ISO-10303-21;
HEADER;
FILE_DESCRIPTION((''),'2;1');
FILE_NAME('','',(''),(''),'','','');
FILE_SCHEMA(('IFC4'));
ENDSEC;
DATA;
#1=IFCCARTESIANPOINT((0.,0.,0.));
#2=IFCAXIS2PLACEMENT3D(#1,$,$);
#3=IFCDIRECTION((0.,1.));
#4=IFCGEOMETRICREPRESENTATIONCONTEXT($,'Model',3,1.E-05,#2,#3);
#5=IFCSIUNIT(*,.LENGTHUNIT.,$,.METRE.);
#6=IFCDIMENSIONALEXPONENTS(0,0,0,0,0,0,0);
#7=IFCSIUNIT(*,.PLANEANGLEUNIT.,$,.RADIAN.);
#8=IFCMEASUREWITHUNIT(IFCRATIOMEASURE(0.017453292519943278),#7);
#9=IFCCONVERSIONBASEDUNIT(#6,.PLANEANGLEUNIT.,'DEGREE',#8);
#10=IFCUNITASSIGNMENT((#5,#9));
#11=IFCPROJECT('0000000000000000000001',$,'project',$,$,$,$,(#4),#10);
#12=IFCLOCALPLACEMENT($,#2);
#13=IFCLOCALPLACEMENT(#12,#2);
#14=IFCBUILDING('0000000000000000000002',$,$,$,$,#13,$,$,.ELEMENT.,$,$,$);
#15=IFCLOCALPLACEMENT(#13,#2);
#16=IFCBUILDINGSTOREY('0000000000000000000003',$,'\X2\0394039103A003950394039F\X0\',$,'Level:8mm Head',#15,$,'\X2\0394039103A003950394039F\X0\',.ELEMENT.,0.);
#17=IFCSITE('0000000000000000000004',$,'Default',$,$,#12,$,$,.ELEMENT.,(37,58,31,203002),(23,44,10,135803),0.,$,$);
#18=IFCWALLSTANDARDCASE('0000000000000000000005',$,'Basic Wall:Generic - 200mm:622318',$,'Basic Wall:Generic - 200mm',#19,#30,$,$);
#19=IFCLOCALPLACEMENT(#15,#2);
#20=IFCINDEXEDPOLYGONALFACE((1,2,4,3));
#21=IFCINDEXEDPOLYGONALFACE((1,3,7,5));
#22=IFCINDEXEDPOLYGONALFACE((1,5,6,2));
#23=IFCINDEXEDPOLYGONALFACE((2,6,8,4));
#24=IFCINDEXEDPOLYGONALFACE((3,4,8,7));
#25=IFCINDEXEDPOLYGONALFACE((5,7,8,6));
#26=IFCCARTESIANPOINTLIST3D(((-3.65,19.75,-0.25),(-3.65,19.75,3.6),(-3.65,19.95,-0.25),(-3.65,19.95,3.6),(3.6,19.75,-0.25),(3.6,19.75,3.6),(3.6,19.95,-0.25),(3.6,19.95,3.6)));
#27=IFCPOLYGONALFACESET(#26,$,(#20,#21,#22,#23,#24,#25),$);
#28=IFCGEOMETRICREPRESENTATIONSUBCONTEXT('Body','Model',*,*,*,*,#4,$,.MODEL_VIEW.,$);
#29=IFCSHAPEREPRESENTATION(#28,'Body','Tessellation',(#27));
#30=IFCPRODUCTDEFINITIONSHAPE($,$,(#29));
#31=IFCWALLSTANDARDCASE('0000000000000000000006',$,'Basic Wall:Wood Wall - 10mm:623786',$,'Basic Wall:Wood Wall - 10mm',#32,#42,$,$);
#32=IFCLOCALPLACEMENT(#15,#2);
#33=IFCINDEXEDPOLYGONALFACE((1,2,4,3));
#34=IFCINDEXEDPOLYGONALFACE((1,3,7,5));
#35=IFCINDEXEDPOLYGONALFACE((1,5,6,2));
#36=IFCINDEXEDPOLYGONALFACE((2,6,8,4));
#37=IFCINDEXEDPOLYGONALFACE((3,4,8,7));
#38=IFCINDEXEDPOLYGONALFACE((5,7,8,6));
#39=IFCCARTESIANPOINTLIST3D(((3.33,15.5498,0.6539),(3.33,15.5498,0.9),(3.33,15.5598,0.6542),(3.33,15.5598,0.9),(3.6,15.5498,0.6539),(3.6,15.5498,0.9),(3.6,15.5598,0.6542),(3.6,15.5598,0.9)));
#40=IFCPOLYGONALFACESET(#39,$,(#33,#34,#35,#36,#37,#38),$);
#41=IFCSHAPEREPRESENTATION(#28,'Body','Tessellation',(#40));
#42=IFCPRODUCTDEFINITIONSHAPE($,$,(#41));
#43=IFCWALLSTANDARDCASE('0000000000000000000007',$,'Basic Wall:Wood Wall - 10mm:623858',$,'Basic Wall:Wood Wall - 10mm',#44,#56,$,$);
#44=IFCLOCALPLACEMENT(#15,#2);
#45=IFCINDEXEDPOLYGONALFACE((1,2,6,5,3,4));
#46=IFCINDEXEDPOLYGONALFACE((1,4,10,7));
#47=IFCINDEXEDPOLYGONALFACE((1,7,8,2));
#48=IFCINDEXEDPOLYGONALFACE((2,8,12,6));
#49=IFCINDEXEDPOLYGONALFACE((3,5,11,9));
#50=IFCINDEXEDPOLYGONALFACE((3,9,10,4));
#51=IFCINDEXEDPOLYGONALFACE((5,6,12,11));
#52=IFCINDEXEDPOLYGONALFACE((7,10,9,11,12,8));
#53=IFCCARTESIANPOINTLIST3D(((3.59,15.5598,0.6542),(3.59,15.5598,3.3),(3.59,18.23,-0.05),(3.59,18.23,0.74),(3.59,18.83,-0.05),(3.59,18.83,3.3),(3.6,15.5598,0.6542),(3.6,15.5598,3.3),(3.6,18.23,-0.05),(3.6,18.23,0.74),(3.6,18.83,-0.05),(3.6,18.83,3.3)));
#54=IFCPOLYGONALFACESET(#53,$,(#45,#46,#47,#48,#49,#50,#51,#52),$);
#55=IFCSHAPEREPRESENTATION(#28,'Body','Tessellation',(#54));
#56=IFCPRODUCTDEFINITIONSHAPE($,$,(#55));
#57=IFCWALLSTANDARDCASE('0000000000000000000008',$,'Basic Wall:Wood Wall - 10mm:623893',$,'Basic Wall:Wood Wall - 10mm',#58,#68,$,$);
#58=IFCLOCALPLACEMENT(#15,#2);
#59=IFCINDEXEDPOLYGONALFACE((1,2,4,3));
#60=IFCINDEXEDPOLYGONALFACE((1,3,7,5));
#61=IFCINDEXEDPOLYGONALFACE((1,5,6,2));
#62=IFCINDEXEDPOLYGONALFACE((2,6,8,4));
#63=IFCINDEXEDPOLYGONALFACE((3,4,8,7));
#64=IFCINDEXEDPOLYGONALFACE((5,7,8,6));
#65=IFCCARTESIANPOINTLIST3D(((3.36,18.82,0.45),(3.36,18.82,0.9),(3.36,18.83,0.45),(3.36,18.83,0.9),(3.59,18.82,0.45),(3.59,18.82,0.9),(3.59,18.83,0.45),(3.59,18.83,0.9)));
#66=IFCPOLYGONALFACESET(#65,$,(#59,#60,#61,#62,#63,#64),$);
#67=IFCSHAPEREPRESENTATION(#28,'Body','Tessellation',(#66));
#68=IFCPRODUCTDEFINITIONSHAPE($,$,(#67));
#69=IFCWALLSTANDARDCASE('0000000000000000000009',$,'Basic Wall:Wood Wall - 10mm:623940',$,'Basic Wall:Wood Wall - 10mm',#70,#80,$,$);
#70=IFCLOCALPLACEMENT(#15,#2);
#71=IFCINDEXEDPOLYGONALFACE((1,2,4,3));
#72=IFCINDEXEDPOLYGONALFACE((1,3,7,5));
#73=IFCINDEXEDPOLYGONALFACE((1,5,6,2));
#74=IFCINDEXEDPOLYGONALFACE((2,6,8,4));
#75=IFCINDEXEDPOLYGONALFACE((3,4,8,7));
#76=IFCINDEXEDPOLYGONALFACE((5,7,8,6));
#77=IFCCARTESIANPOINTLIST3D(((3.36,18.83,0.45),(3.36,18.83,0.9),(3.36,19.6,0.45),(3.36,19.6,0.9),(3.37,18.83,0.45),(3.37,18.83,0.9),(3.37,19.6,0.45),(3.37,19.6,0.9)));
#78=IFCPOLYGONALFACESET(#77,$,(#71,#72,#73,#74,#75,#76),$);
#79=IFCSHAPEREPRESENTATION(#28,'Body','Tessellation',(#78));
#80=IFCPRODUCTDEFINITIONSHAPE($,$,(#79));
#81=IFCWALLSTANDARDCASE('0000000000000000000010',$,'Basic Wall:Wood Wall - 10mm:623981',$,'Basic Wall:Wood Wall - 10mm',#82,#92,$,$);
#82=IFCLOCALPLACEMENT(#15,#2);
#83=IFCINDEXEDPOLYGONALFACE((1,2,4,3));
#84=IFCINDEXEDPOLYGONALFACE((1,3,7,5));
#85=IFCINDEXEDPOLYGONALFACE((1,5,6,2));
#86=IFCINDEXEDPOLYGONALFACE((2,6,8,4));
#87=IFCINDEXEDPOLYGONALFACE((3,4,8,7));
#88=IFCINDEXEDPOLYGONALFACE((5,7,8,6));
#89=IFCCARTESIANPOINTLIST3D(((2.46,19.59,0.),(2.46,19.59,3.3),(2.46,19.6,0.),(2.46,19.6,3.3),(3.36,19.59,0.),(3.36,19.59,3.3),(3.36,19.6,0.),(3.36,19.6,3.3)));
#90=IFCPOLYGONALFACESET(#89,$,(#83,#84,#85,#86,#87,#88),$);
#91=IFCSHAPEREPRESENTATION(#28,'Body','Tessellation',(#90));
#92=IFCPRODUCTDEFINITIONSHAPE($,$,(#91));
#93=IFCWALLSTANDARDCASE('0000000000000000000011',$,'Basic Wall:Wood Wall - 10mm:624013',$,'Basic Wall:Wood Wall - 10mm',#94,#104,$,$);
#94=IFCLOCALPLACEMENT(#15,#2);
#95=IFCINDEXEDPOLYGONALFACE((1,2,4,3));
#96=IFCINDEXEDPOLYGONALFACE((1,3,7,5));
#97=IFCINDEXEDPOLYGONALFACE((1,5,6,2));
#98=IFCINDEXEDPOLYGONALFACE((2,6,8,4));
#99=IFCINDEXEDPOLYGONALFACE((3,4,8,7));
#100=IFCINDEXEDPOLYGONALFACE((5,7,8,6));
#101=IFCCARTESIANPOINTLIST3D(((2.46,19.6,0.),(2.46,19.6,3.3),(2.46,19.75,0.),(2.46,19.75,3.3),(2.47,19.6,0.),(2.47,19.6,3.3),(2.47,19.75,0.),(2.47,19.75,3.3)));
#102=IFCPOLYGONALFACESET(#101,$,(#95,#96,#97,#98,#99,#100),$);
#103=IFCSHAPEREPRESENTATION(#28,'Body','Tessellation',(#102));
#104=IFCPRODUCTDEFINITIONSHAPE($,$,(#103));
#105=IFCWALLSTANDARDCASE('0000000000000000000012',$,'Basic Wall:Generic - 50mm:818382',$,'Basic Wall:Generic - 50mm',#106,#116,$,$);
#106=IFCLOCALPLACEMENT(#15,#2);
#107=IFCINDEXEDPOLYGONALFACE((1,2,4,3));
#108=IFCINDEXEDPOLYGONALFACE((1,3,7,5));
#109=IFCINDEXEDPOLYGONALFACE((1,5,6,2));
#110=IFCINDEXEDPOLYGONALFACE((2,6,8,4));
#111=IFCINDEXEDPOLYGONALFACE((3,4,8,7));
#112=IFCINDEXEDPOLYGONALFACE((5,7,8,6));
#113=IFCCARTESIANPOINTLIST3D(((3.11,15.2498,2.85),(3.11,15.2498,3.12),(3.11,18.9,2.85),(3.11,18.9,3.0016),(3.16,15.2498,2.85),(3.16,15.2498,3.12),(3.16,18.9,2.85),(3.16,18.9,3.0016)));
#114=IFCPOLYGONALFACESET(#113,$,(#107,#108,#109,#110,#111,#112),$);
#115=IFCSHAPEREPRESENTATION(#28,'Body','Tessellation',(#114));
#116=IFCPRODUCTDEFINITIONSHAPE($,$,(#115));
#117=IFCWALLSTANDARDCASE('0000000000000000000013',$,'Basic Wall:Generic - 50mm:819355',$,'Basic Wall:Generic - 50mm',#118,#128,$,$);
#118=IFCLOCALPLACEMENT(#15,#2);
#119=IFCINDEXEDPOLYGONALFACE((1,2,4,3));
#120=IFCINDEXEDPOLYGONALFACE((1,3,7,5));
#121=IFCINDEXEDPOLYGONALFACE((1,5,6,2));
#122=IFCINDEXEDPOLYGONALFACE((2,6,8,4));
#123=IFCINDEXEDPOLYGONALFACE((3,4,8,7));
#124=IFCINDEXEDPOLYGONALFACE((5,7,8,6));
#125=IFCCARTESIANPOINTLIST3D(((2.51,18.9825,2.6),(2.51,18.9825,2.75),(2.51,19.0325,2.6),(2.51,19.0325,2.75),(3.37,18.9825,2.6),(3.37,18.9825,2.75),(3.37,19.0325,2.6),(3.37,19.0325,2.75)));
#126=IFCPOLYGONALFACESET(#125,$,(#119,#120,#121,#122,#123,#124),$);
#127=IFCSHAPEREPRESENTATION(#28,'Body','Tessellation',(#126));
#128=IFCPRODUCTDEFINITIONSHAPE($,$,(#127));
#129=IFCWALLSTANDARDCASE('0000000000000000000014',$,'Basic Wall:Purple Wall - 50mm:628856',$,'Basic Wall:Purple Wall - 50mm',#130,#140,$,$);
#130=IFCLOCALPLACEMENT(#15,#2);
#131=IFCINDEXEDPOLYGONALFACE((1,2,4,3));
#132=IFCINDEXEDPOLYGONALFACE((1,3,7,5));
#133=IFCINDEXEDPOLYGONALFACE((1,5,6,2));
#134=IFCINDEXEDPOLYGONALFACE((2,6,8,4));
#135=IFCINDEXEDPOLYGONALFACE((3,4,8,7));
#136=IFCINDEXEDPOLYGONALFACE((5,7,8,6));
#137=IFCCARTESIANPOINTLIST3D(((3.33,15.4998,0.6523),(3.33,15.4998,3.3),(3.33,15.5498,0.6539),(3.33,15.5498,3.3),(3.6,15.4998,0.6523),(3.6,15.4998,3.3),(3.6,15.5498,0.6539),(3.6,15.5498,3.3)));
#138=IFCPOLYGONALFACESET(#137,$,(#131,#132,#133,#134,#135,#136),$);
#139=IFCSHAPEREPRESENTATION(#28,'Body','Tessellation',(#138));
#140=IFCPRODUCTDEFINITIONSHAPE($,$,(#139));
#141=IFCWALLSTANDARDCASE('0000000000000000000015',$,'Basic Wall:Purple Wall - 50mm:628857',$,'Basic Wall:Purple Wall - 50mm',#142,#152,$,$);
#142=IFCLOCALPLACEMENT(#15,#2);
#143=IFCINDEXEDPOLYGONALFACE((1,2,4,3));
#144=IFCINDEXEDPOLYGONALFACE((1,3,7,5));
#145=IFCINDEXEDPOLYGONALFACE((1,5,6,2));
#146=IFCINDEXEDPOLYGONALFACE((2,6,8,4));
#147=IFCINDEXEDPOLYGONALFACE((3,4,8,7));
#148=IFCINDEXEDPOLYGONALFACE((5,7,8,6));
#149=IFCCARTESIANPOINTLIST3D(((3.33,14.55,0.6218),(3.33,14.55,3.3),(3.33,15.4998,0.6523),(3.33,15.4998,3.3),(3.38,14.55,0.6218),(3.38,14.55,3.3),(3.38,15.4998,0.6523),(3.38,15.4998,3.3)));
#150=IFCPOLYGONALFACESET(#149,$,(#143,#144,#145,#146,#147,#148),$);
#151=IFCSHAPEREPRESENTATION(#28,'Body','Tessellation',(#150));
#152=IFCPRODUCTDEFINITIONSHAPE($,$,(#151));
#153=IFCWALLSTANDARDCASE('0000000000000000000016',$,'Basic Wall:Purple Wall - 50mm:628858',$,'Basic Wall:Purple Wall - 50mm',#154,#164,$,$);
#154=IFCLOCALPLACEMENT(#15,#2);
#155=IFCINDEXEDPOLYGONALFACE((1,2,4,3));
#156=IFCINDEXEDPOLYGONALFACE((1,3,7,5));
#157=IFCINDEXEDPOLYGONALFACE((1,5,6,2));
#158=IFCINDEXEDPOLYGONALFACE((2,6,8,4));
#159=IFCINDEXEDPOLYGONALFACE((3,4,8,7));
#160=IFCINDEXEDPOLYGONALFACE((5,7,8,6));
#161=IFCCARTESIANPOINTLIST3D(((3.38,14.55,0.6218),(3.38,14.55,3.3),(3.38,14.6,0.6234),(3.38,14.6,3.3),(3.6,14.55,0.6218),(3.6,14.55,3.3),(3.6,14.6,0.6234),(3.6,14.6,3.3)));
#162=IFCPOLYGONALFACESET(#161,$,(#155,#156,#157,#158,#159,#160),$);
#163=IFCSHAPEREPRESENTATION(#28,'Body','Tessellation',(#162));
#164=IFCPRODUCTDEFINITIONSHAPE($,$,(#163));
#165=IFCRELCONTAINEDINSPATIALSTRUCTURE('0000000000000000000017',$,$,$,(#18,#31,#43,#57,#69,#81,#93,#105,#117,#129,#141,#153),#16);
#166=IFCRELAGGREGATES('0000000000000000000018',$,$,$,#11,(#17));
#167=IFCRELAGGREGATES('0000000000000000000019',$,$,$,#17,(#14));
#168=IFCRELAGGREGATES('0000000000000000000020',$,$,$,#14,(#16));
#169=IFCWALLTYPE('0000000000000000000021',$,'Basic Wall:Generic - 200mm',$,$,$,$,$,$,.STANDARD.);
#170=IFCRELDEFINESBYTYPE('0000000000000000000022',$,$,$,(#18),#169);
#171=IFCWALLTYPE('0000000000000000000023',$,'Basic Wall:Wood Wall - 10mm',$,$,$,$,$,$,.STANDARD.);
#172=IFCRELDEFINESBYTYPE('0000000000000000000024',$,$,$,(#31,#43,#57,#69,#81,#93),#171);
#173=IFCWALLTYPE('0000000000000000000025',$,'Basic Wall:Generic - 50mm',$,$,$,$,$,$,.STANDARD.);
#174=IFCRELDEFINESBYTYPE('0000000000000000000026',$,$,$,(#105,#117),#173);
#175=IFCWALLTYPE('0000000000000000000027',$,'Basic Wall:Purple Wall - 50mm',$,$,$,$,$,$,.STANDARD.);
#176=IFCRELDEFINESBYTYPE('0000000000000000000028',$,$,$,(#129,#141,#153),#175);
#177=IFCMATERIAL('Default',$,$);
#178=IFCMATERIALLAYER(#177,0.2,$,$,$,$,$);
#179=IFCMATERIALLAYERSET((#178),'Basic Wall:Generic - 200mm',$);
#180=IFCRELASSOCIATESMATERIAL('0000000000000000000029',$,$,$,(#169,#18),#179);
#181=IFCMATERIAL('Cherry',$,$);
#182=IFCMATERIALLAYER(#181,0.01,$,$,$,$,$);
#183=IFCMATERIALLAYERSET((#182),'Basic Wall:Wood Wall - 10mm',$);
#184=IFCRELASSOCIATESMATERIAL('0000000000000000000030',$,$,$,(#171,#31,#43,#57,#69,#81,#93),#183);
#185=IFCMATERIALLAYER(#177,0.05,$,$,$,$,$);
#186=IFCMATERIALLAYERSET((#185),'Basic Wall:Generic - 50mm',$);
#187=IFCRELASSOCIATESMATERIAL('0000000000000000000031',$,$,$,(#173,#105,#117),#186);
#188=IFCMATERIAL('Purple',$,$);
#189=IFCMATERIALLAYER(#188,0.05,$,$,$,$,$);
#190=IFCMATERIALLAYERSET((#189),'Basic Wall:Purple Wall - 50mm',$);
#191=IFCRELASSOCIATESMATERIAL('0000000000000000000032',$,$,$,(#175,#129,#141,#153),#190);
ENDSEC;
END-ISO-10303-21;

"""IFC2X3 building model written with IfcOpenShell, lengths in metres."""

from ifc_helpers import new_model, entity, si_unit, converted_unit, direction, frame, frame_2d, origin, place, context, subcontext, project, spatial, polyline, rectangle, extrude, clip, bounded_halfspace, material, layer, layer_set, layer_usage, type_object, element, save


model = new_model("IFC2X3")

# Units and contexts
model_context = context("Model", 3, precision=1e-05, world=origin(), true_north=direction((0.0, 1.0)))
body_context = subcontext(model_context, "Body", "Model", "MODEL_VIEW")
ifc_project = project(units=[si_unit("LENGTHUNIT", "METRE"), converted_unit("PLANEANGLEUNIT", "DEGREE", entity("IfcRatioMeasure", 0.017453292519943278), si_unit("PLANEANGLEUNIT", "RADIAN"), dimensions=[0, 0, 0, 0, 0, 0, 0])], contexts=[model_context])

# Site, building, storey
site_placement = place(None, origin())
site = spatial("IfcSite", under=ifc_project, at=site_placement, Name="Default", CompositionType="ELEMENT", RefLatitude=(37, 58, 31, 203002), RefLongitude=(23, 44, 10, 135803), RefElevation=0.0)
building_placement = place(site_placement, origin())
building = spatial("IfcBuilding", under=site, at=building_placement, CompositionType="ELEMENT")
storey_placement = place(building_placement, origin())
storey = spatial("IfcBuildingStorey", under=building, at=storey_placement, Name="ΔΑΠΕΔΟ", ObjectType="Level:8mm Head", LongName="ΔΑΠΕΔΟ", CompositionType="ELEMENT", Elevation=0.0)

# Walls
ifc_material_1 = material(Name="Default")
ifc_layer_1 = layer(ifc_material_1, 0.2)
ifc_layer_set_1 = layer_set([ifc_layer_1], Name="Basic Wall:Generic - 200mm")
ifc_layer_usage_1 = layer_usage(ifc_layer_set_1, "AXIS2", "NEGATIVE", 0.1)
wall_type_1 = type_object("IfcWallType", Name="Basic Wall:Generic - 200mm", PredefinedType="STANDARD", material=ifc_layer_set_1)
wall_1_placement = place(storey_placement, frame((3.6, 19.85, -0.25), z_axis=(0.0, 0.0, 1.0), x_axis=(-1.0, 0.0, 0.0)))
element("IfcWallStandardCase", 1, at=wall_1_placement, inside=storey, type_object=wall_type_1, material=ifc_layer_usage_1, Name="Basic Wall:Generic - 200mm:622318", ObjectType="Basic Wall:Generic - 200mm", context=body_context, shape_type="SweptSolid", body=[
    extrude(rectangle(XDim=7.25, YDim=0.2, at=frame_2d((3.625, 0.0), x_axis=(-1.0, 0.0))), origin(), (0.0, 0.0, 1.0), 3.85),
])
ifc_material_2 = material(Name="Cherry")
ifc_layer_2 = layer(ifc_material_2, 0.01)
ifc_layer_set_2 = layer_set([ifc_layer_2], Name="Basic Wall:Wood Wall - 10mm")
ifc_layer_usage_2 = layer_usage(ifc_layer_set_2, "AXIS2", "NEGATIVE", 0.005)
wall_type_2 = type_object("IfcWallType", Name="Basic Wall:Wood Wall - 10mm", PredefinedType="STANDARD", material=ifc_layer_set_2)
wall_2_placement = place(storey_placement, frame((3.33, 15.5548, 0.6539)))
element("IfcWallStandardCase", 2, at=wall_2_placement, inside=storey, type_object=wall_type_2, material=ifc_layer_usage_2, Name="Basic Wall:Wood Wall - 10mm:623786", ObjectType="Basic Wall:Wood Wall - 10mm", context=body_context, shape_type="Clipping", body=[
    clip(extrude(rectangle(XDim=0.27, YDim=0.01, at=frame_2d((0.135, 0.0), x_axis=(-1.0, 0.0))), origin(), (0.0, 0.0, 1.0), 0.2461), bounded_halfspace(frame((0.27, -0.005, 0.0), z_axis=(0.0, -0.032108, 0.999484), x_axis=(1.0, 0.0, 0.0)), True, frame((0.27, -0.005, 0.0)), polyline([(0.0, 0.0), (0.0, 0.01), (-0.01, 0.01), (-0.27, 0.01), (-0.27, 0.0), (0.0, 0.0)]))),
])
wall_3_placement = place(storey_placement, frame((3.595, 15.5598, -0.05), z_axis=(0.0, 0.0, 1.0), x_axis=(0.0, 1.0, 0.0)))
element("IfcWallStandardCase", 3, at=wall_3_placement, inside=storey, type_object=wall_type_2, material=ifc_layer_usage_2, Name="Basic Wall:Wood Wall - 10mm:623858", ObjectType="Basic Wall:Wood Wall - 10mm", context=body_context, shape_type="Clipping", body=[
    clip(clip(extrude(rectangle(XDim=3.2702, YDim=0.01, at=frame_2d((1.6351, 0.0), x_axis=(-1.0, 0.0))), origin(), (0.0, 0.0, 1.0), 3.35), bounded_halfspace(frame((2.6702, -0.005, 0.79), z_axis=(-0.032108, 0.0, 0.999484), x_axis=(0.0, -1.0, 0.0)), True, frame((2.6702, -0.005, 0.79)), polyline([(0.0, 0.0), (0.0, 0.01), (-2.6702, 0.01), (-2.6702, 0.0), (0.0, 0.0)]))), bounded_halfspace(frame((3.2702, -0.005, 0.0)), True, frame((3.2702, -0.005, 0.0)), polyline([(0.0, 0.0), (0.0, 0.01), (-0.6, 0.01), (-0.6, 0.0), (0.0, 0.0)]))),
])
wall_4_placement = place(storey_placement, frame((3.59, 18.825, 0.45), z_axis=(0.0, 0.0, 1.0), x_axis=(-1.0, 0.0, 0.0)))
element("IfcWallStandardCase", 4, at=wall_4_placement, inside=storey, type_object=wall_type_2, material=ifc_layer_usage_2, Name="Basic Wall:Wood Wall - 10mm:623893", ObjectType="Basic Wall:Wood Wall - 10mm", context=body_context, shape_type="SweptSolid", body=[
    extrude(rectangle(XDim=0.23, YDim=0.01, at=frame_2d((0.115, 0.0), x_axis=(-1.0, 0.0))), origin(), (0.0, 0.0, 1.0), 0.45),
])
wall_5_placement = place(storey_placement, frame((3.365, 18.83, 0.45), z_axis=(0.0, 0.0, 1.0), x_axis=(0.0, 1.0, 0.0)))
element("IfcWallStandardCase", 5, at=wall_5_placement, inside=storey, type_object=wall_type_2, material=ifc_layer_usage_2, Name="Basic Wall:Wood Wall - 10mm:623940", ObjectType="Basic Wall:Wood Wall - 10mm", context=body_context, shape_type="SweptSolid", body=[
    extrude(rectangle(XDim=0.77, YDim=0.01, at=frame_2d((0.385, 0.0), x_axis=(-1.0, 0.0))), origin(), (0.0, 0.0, 1.0), 0.45),
])
wall_6_placement = place(storey_placement, frame((3.36, 19.595, 0.0), z_axis=(0.0, 0.0, 1.0), x_axis=(-1.0, 0.0, 0.0)))
element("IfcWallStandardCase", 6, at=wall_6_placement, inside=storey, type_object=wall_type_2, material=ifc_layer_usage_2, Name="Basic Wall:Wood Wall - 10mm:623981", ObjectType="Basic Wall:Wood Wall - 10mm", context=body_context, shape_type="SweptSolid", body=[
    extrude(rectangle(XDim=0.9, YDim=0.01, at=frame_2d((0.45, 0.0), x_axis=(-1.0, 0.0))), origin(), (0.0, 0.0, 1.0), 3.3),
])
wall_7_placement = place(storey_placement, frame((2.465, 19.6, 0.0), z_axis=(0.0, 0.0, 1.0), x_axis=(0.0, 1.0, 0.0)))
element("IfcWallStandardCase", 7, at=wall_7_placement, inside=storey, type_object=wall_type_2, material=ifc_layer_usage_2, Name="Basic Wall:Wood Wall - 10mm:624013", ObjectType="Basic Wall:Wood Wall - 10mm", context=body_context, shape_type="SweptSolid", body=[
    extrude(rectangle(XDim=0.15, YDim=0.01, at=frame_2d((0.075, 0.0), x_axis=(-1.0, 0.0))), origin(), (0.0, 0.0, 1.0), 3.3),
])
ifc_layer_3 = layer(ifc_material_1, 0.05)
ifc_layer_set_3 = layer_set([ifc_layer_3], Name="Basic Wall:Generic - 50mm")
ifc_layer_usage_3 = layer_usage(ifc_layer_set_3, "AXIS2", "NEGATIVE", 0.025)
wall_type_3 = type_object("IfcWallType", Name="Basic Wall:Generic - 50mm", PredefinedType="STANDARD", material=ifc_layer_set_3)
wall_8_placement = place(storey_placement, frame((3.135, 15.2498, 2.85), z_axis=(0.0, 0.0, 1.0), x_axis=(0.0, 1.0, 0.0)))
element("IfcWallStandardCase", 8, at=wall_8_placement, inside=storey, type_object=wall_type_3, material=ifc_layer_usage_3, Name="Basic Wall:Generic - 50mm:818382", ObjectType="Basic Wall:Generic - 50mm", context=body_context, shape_type="Clipping", body=[
    clip(extrude(rectangle(XDim=3.6502, YDim=0.05, at=frame_2d((1.8251, 0.0), x_axis=(-1.0, 0.0))), origin(), (0.0, 0.0, 1.0), 0.27), bounded_halfspace(frame((0.0, -0.025, 0.27), z_axis=(-0.032414, 0.0, -0.999475), x_axis=(0.999475, 0.0, -0.032414)), True, frame((0.0, -0.025, 0.27)), polyline([(0.0, 0.0), (3.6502, 0.0), (3.6502, 0.05), (0.0, 0.05), (0.0, 0.0)]))),
])
wall_9_placement = place(storey_placement, frame((2.51, 19.0075, 2.6)))
element("IfcWallStandardCase", 9, at=wall_9_placement, inside=storey, type_object=wall_type_3, material=ifc_layer_usage_3, Name="Basic Wall:Generic - 50mm:819355", ObjectType="Basic Wall:Generic - 50mm", context=body_context, shape_type="SweptSolid", body=[
    extrude(rectangle(XDim=0.86, YDim=0.05, at=frame_2d((0.43, 0.0), x_axis=(-1.0, 0.0))), origin(), (0.0, 0.0, 1.0), 0.15),
])

# Walls
ifc_material_3 = material(Name="Purple")
ifc_layer_4 = layer(ifc_material_3, 0.05)
ifc_layer_set_4 = layer_set([ifc_layer_4], Name="Basic Wall:Purple Wall - 50mm")
ifc_layer_usage_4 = layer_usage(ifc_layer_set_4, "AXIS2", "POSITIVE", -0.025)
wall_type_4 = type_object("IfcWallType", Name="Basic Wall:Purple Wall - 50mm", PredefinedType="STANDARD", material=ifc_layer_set_4)
wall_10_placement = place(storey_placement, frame((3.6, 15.5248, 0.6523), z_axis=(0.0, 0.0, 1.0), x_axis=(-1.0, 0.0, 0.0)))
element("IfcWallStandardCase", 10, at=wall_10_placement, inside=storey, type_object=wall_type_4, material=ifc_layer_usage_4, Name="Basic Wall:Purple Wall - 50mm:628856", ObjectType="Basic Wall:Purple Wall - 50mm", context=body_context, shape_type="Clipping", body=[
    clip(extrude(rectangle(XDim=0.27, YDim=0.05, at=frame_2d((0.135, 0.0), x_axis=(-1.0, 0.0))), origin(), (0.0, 0.0, 1.0), 2.6477), bounded_halfspace(frame((0.27, -0.025, 0.0016), z_axis=(0.0, 0.032108, 0.999484), x_axis=(-1.0, 0.0, 0.0)), True, frame((0.27, -0.025, 0.0016)), polyline([(0.0, 0.0), (0.0, 0.05), (-0.05, 0.05), (-0.27, 0.05), (-0.27, 0.0), (0.0, 0.0)]))),
])
wall_11_placement = place(storey_placement, frame((3.355, 15.4998, 0.6218), z_axis=(0.0, 0.0, 1.0), x_axis=(0.0, -1.0, 0.0)))
element("IfcWallStandardCase", 11, at=wall_11_placement, inside=storey, type_object=wall_type_4, material=ifc_layer_usage_4, Name="Basic Wall:Purple Wall - 50mm:628857", ObjectType="Basic Wall:Purple Wall - 50mm", context=body_context, shape_type="Clipping", body=[
    clip(extrude(rectangle(XDim=0.9498, YDim=0.05, at=frame_2d((0.4749, 0.0), x_axis=(-1.0, 0.0))), origin(), (0.0, 0.0, 1.0), 2.6782), bounded_halfspace(frame((0.9498, -0.025, 0.0), z_axis=(0.032108, 0.0, 0.999484), x_axis=(0.0, 1.0, 0.0)), True, frame((0.9498, -0.025, 0.0)), polyline([(0.0, 0.0), (0.0, 0.05), (-0.05, 0.05), (-0.9498, 0.05), (-0.9498, 0.0), (0.0, 0.0)]))),
])
wall_12_placement = place(storey_placement, frame((3.38, 14.575, 0.6218)))
element("IfcWallStandardCase", 12, at=wall_12_placement, inside=storey, type_object=wall_type_4, material=ifc_layer_usage_4, Name="Basic Wall:Purple Wall - 50mm:628858", ObjectType="Basic Wall:Purple Wall - 50mm", context=body_context, shape_type="Clipping", body=[
    clip(extrude(rectangle(XDim=0.22, YDim=0.05, at=frame_2d((0.11, 0.0), x_axis=(-1.0, 0.0))), origin(), (0.0, 0.0, 1.0), 2.6782), bounded_halfspace(frame((0.22, -0.025, 0.0), z_axis=(0.0, -0.032108, 0.999484), x_axis=(1.0, 0.0, 0.0)), True, frame((0.22, -0.025, 0.0)), polyline([(0.0, 0.0), (0.0, 0.05), (-0.22, 0.05), (-0.22, 0.0), (-0.01, 0.0), (0.0, 0.0)]))),
])

save(model, "model.ifc")
